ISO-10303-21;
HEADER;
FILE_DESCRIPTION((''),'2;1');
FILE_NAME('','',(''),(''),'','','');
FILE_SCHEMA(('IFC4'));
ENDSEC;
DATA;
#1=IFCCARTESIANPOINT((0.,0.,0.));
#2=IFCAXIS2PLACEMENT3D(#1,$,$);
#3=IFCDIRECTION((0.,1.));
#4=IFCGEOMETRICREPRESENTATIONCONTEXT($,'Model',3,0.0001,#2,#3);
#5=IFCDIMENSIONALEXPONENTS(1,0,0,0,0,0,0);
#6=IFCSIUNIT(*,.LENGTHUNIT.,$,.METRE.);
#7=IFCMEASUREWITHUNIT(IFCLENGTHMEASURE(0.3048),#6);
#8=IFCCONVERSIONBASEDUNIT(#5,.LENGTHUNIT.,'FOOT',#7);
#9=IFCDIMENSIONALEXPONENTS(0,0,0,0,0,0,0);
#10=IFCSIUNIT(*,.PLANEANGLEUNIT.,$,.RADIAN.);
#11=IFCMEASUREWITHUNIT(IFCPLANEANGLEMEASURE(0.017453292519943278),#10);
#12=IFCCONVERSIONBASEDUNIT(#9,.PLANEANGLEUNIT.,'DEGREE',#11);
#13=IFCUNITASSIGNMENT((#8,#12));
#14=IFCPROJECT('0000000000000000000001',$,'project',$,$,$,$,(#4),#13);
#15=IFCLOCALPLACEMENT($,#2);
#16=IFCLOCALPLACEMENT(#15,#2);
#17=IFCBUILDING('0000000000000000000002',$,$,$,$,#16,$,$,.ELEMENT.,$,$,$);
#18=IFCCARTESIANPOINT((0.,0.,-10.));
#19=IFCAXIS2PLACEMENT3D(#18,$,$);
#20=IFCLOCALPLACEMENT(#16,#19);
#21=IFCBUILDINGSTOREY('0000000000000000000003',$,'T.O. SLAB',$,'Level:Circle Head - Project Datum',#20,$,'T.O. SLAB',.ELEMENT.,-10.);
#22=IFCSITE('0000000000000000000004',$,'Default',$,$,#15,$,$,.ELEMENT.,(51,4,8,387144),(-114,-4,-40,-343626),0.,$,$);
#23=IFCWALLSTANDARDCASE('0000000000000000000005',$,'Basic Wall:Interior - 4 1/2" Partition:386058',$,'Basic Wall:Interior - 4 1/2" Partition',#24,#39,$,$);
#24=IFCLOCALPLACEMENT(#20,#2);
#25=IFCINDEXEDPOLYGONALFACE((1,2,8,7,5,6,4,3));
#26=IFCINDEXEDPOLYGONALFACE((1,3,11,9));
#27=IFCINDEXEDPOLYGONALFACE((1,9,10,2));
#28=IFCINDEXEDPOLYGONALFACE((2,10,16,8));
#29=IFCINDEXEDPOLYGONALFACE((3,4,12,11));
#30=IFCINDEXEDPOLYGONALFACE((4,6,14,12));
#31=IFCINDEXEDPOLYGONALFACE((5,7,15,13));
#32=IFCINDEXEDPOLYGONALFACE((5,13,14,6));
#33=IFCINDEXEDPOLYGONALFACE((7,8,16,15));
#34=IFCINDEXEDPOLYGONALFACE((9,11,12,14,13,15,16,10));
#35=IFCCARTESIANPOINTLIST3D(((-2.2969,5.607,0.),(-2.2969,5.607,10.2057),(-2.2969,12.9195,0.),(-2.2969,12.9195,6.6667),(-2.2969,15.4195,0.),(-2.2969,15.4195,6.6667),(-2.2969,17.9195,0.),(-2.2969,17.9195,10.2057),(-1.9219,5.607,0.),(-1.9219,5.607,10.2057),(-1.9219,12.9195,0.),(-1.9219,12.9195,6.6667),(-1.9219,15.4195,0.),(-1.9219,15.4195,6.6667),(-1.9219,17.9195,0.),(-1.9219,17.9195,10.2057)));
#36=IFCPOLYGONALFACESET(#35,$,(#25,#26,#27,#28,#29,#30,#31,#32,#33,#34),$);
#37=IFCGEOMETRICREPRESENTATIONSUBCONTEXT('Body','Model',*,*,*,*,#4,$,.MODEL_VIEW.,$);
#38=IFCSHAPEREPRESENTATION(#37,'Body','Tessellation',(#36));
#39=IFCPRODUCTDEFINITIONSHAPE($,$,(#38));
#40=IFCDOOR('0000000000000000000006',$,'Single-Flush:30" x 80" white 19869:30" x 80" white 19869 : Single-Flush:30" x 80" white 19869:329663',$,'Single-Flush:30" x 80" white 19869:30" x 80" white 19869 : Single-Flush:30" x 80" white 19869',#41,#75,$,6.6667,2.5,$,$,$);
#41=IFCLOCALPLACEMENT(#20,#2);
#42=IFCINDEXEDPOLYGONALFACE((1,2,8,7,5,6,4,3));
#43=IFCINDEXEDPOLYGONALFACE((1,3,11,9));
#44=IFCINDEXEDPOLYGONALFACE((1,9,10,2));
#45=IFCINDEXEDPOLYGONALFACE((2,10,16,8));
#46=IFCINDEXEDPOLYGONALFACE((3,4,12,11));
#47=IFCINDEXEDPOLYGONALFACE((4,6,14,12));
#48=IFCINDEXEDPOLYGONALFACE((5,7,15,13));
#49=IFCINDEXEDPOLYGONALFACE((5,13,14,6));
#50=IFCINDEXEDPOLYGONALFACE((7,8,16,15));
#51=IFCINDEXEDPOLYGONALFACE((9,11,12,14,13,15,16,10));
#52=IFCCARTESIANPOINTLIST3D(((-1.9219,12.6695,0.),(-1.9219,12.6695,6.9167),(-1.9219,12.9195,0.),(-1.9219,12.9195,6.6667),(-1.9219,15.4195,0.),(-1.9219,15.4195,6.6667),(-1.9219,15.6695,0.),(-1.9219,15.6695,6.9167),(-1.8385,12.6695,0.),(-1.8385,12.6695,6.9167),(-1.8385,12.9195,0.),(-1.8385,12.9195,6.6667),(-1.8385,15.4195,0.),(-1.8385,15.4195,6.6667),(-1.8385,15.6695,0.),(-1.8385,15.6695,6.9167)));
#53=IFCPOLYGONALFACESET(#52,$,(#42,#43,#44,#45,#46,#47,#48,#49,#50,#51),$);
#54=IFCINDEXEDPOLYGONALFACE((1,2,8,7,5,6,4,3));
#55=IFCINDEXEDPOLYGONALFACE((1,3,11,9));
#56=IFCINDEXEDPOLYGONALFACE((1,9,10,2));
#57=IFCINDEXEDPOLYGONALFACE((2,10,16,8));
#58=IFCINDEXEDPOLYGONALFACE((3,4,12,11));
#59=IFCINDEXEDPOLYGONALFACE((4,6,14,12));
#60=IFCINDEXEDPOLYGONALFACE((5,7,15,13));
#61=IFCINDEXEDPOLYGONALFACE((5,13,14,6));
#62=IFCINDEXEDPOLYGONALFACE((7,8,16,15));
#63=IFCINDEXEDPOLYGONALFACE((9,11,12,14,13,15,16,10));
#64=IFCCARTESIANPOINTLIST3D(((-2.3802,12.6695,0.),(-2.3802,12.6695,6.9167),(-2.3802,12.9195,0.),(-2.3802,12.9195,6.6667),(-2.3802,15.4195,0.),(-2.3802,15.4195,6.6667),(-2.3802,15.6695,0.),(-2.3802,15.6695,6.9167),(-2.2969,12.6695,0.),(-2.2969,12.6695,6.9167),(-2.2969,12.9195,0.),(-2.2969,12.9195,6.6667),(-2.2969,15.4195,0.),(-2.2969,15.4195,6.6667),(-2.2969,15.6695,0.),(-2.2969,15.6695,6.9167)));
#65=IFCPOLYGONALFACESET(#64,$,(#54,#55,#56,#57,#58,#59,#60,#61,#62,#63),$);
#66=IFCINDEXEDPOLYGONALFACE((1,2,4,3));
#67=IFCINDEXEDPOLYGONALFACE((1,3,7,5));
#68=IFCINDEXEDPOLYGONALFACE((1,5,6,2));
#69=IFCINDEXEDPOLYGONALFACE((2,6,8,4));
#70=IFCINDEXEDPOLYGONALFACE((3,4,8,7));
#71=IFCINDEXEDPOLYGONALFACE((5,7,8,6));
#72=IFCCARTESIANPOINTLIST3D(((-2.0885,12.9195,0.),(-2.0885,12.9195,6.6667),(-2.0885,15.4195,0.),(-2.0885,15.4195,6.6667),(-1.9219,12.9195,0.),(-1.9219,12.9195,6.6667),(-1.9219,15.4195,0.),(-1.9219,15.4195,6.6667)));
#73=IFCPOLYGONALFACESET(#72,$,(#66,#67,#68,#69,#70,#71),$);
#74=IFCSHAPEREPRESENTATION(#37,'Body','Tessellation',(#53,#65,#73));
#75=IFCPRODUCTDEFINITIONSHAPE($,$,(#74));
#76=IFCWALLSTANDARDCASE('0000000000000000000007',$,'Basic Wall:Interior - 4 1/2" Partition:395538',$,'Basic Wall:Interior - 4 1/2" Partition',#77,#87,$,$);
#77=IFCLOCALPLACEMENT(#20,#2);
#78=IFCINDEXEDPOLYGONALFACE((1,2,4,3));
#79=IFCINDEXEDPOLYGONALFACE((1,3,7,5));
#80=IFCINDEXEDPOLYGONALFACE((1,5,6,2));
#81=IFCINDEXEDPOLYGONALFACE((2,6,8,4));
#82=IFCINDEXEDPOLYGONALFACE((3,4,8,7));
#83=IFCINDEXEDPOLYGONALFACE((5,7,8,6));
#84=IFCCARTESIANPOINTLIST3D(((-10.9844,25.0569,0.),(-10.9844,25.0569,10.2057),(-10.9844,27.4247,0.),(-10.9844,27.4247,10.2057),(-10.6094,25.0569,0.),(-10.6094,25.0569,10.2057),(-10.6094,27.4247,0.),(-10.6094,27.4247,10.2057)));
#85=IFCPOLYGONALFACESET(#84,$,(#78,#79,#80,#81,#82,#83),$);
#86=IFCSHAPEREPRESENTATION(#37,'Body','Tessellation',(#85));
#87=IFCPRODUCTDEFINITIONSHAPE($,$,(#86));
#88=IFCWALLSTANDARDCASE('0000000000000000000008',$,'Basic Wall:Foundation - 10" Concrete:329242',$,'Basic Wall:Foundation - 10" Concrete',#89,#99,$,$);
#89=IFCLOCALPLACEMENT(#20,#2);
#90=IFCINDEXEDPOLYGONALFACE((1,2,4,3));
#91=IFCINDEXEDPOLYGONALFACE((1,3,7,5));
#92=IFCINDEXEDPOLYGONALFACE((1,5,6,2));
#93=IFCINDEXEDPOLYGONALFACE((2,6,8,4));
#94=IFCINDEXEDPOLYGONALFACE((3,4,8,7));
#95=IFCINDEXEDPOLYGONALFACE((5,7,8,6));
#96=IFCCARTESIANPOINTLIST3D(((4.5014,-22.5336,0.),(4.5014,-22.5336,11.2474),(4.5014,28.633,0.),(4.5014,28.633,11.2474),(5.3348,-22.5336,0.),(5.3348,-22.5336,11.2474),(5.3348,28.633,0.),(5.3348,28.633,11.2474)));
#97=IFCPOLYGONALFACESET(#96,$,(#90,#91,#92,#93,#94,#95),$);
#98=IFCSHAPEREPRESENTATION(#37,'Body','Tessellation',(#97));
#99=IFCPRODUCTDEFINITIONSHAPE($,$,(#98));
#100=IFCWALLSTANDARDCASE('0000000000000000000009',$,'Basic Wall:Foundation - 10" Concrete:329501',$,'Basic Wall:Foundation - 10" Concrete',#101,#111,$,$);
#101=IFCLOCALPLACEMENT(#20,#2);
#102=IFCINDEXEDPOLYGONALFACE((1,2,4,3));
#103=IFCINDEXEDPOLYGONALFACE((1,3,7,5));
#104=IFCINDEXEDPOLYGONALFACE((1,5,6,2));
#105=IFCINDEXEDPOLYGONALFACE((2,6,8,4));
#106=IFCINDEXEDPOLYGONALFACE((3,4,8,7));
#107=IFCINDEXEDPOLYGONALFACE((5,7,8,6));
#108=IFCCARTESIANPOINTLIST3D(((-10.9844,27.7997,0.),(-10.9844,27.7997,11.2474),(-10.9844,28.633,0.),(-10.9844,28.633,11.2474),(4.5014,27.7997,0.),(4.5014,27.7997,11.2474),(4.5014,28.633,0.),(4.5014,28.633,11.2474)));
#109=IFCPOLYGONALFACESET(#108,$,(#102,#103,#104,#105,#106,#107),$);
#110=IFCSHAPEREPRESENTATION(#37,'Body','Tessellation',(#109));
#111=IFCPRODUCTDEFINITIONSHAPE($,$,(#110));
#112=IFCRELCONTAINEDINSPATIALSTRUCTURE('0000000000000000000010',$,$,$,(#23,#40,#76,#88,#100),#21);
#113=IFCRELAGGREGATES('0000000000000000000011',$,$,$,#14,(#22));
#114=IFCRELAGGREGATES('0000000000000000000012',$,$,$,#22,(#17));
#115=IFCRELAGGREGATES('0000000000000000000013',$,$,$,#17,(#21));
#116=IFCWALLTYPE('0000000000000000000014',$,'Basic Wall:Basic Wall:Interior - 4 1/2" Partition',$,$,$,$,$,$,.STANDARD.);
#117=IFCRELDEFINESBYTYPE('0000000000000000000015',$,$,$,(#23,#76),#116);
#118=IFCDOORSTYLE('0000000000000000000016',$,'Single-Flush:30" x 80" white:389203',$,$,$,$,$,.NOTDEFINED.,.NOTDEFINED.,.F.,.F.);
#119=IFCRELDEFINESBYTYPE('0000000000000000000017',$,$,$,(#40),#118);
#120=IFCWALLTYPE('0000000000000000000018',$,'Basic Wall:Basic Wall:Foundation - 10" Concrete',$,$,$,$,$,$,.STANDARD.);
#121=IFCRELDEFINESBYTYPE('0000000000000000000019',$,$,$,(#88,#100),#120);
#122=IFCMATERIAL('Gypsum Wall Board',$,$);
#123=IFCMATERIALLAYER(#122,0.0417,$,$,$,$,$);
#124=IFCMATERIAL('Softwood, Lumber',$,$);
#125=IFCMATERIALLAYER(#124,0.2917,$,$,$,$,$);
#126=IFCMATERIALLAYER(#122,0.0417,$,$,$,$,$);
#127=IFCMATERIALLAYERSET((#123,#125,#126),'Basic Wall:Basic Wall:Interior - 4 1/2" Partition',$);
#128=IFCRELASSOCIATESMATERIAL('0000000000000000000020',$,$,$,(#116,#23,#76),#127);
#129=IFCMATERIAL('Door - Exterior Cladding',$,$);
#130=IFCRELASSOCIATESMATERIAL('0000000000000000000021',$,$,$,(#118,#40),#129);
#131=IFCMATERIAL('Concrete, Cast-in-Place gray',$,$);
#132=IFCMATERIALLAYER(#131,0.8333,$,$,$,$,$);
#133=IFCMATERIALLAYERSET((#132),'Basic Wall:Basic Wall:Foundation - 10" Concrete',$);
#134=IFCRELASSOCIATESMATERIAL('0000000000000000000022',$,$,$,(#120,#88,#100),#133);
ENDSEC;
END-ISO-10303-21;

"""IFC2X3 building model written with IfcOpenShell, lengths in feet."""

from ifc_helpers import new_model, entity, si_unit, converted_unit, direction, frame, frame_2d, origin, place, context, subcontext, project, spatial, polyline, rectangle, outline, extrude, source, transform, mapped, material, layer, layer_set, layer_usage, type_object, type_shapes, element, fill, save


model = new_model("IFC2X3")

# Units and contexts
model_context = context("Model", 3, precision=0.0001, world=origin(), true_north=direction((0.0, 1.0)))
body_context = subcontext(model_context, "Body", "Model", "MODEL_VIEW")
ifc_project = project(units=[converted_unit("LENGTHUNIT", "FOOT", entity("IfcLengthMeasure", 0.3048), si_unit("LENGTHUNIT", "METRE"), dimensions=[1, 0, 0, 0, 0, 0, 0]), converted_unit("PLANEANGLEUNIT", "DEGREE", entity("IfcPlaneAngleMeasure", 0.017453292519943278), si_unit("PLANEANGLEUNIT", "RADIAN"), dimensions=[0, 0, 0, 0, 0, 0, 0])], contexts=[model_context])

# Site, building, storey
site_placement = place(None, origin())
site = spatial("IfcSite", under=ifc_project, at=site_placement, Name="Default", CompositionType="ELEMENT", RefLatitude=(51, 4, 8, 387144), RefLongitude=(-114, -4, -40, -343626), RefElevation=0.0)
building_placement = place(site_placement, origin())
building = spatial("IfcBuilding", under=site, at=building_placement, CompositionType="ELEMENT")
storey_placement = place(building_placement, frame((0.0, 0.0, -10.0)))
storey = spatial("IfcBuildingStorey", under=building, at=storey_placement, Name="T.O. SLAB", ObjectType="Level:Circle Head - Project Datum", LongName="T.O. SLAB", CompositionType="ELEMENT", Elevation=-10.0)

# Shared definitions
ifc_material_1 = material(Name="Gypsum Wall Board")
ifc_layer_1 = layer(ifc_material_1, 0.0417)
ifc_material_2 = material(Name="Softwood, Lumber")
ifc_layer_2 = layer(ifc_material_2, 0.2917)
ifc_layer_3 = layer(ifc_material_1, 0.0417)
ifc_layer_set_1 = layer_set([ifc_layer_1, ifc_layer_2, ifc_layer_3], Name="Basic Wall:Basic Wall:Interior - 4 1/2\" Partition")
wall_type_1 = type_object("IfcWallType", Name="Basic Wall:Basic Wall:Interior - 4 1/2\" Partition", PredefinedType="STANDARD", material=ifc_layer_set_1)
ifc_material_3 = material(Name="Door - Exterior Cladding")

# Wall, opening, door
ifc_layer_usage_1 = layer_usage(ifc_layer_set_1, "AXIS2", "NEGATIVE", 0.1875)
wall_1_placement = place(storey_placement, frame((-2.1094, 17.9195, 0.0), z_axis=(0.0, 0.0, 1.0), x_axis=(0.0, -1.0, 0.0)))
wall_1 = element("IfcWallStandardCase", 1, at=wall_1_placement, inside=storey, type_object=wall_type_1, material=ifc_layer_usage_1, Name="Basic Wall:Interior - 4 1/2\" Partition:386058", ObjectType="Basic Wall:Interior - 4 1/2\" Partition", context=body_context, shape_type="SweptSolid", body=[
    extrude(rectangle(XDim=12.3125, YDim=0.375, at=frame_2d((6.1563, 0.0), x_axis=(1.0, 0.0))), origin(), (0.0, 0.0, 1.0), 10.2057),
])
opening_1_placement = place(wall_1_placement, frame((17.9195, 2.1094, 0.0), z_axis=(0.0, 0.0, 1.0), x_axis=(0.0, 1.0, 0.0)))
opening_1 = element("IfcOpeningElement", 2, at=opening_1_placement, cuts=wall_1, ObjectType="Opening", context=body_context, shape_type="SweptSolid", body=[
    extrude(rectangle(XDim=6.6667, YDim=2.5, at=frame_2d((0.0, 0.0), x_axis=(1.0, 0.0))), frame((-2.3006, 14.1695, 3.3333), z_axis=(1.0, 0.0, 0.0), x_axis=(0.0, 0.0, 1.0)), (0.0, 0.0, 1.0), 0.3825),
])
door_style_1 = type_object("IfcDoorStyle", Name="Single-Flush:30\" x 80\" white:389203", ConstructionType="NOTDEFINED", OperationType="NOTDEFINED", ParameterTakesPrecedence=False, Sizeable=False, material=ifc_material_3)
shared_shape_1 = source(origin(), body_context, "Body", "SweptSolid", [
    extrude(outline(polyline([(-1.5, -3.5208), (1.5, -3.5208), (1.5, 3.3958), (1.25, 3.3958), (1.25, -3.2708), (-1.25, -3.2708), (-1.25, 3.3958), (-1.5, 3.3958), (-1.5, -3.5208)])), frame((1.25, -0.0038, 3.3958), z_axis=(0.0, 1.0, 0.0), x_axis=(1.0, 0.0, 0.0)), (0.0, 0.0, 1.0), 0.0833),
    extrude(outline(polyline([(-3.3958, -1.5), (3.5208, -1.5), (3.5208, 1.5), (-3.3958, 1.5), (-3.3958, 1.25), (3.2708, 1.25), (3.2708, -1.25), (-3.3958, -1.25), (-3.3958, -1.5)])), frame((1.25, -0.4621, 3.3958), z_axis=(0.0, 1.0, 0.0), x_axis=(0.0, 0.0, 1.0)), (0.0, 0.0, 1.0), 0.0833),
    extrude(rectangle(XDim=0.1667, YDim=2.5, at=frame_2d((0.0, 0.0), x_axis=(1.0, 0.0))), frame((1.25, -0.0871, 0.0), z_axis=(0.0, 0.0, 1.0), x_axis=(0.0, 1.0, 0.0)), (0.0, 0.0, 1.0), 6.6667),
])
type_shapes(door_style_1, [shared_shape_1])
door_1_placement = place(opening_1_placement, frame((-1.9181, 15.4195, 0.0), z_axis=(0.0, 0.0, 1.0), x_axis=(0.0, -1.0, 0.0)))
door_1 = element("IfcDoor", 3, at=door_1_placement, inside=storey, type_object=door_style_1, material=ifc_material_3, Name="Single-Flush:30\" x 80\" white 19869:30\" x 80\" white 19869 : Single-Flush:30\" x 80\" white 19869:329663", ObjectType="Single-Flush:30\" x 80\" white 19869:30\" x 80\" white 19869 : Single-Flush:30\" x 80\" white 19869", OverallHeight=6.6667, OverallWidth=2.5, context=body_context, shape_type="MappedRepresentation", body=[
    mapped(shared_shape_1, transform((0.0, 0.0, 0.0), scale=1.0)),
])
fill(opening_1, door_1)

# Walls
ifc_layer_usage_2 = layer_usage(ifc_layer_set_1, "AXIS2", "NEGATIVE", 0.1875)
wall_2_placement = place(storey_placement, frame((-10.7969, 25.0569, 0.0), z_axis=(0.0, 0.0, 1.0), x_axis=(0.0, 1.0, 0.0)))
element("IfcWallStandardCase", 4, at=wall_2_placement, inside=storey, type_object=wall_type_1, material=ifc_layer_usage_2, Name="Basic Wall:Interior - 4 1/2\" Partition:395538", ObjectType="Basic Wall:Interior - 4 1/2\" Partition", context=body_context, shape_type="SweptSolid", body=[
    extrude(rectangle(XDim=2.3678, YDim=0.375, at=frame_2d((1.1839, 0.0), x_axis=(-1.0, 0.0))), origin(), (0.0, 0.0, 1.0), 10.2057),
])
ifc_material_4 = material(Name="Concrete, Cast-in-Place gray")
ifc_layer_4 = layer(ifc_material_4, 0.8333)
ifc_layer_set_2 = layer_set([ifc_layer_4], Name="Basic Wall:Basic Wall:Foundation - 10\" Concrete")
ifc_layer_usage_3 = layer_usage(ifc_layer_set_2, "AXIS2", "NEGATIVE", 0.4167)
wall_type_2 = type_object("IfcWallType", Name="Basic Wall:Basic Wall:Foundation - 10\" Concrete", PredefinedType="STANDARD", material=ifc_layer_set_2)
wall_3_placement = place(storey_placement, frame((4.9181, 28.633, 0.0), z_axis=(0.0, 0.0, 1.0), x_axis=(0.0, -1.0, 0.0)))
element("IfcWallStandardCase", 5, at=wall_3_placement, inside=storey, type_object=wall_type_2, material=ifc_layer_usage_3, Name="Basic Wall:Foundation - 10\" Concrete:329242", ObjectType="Basic Wall:Foundation - 10\" Concrete", context=body_context, shape_type="SweptSolid", body=[
    extrude(rectangle(XDim=51.1667, YDim=0.8333, at=frame_2d((25.5833, 0.0), x_axis=(-1.0, 0.0))), origin(), (0.0, 0.0, 1.0), 11.2474),
])
ifc_layer_usage_4 = layer_usage(ifc_layer_set_2, "AXIS2", "NEGATIVE", 0.4167)
wall_4_placement = place(storey_placement, frame((-10.9844, 28.2164, 0.0)))
element("IfcWallStandardCase", 6, at=wall_4_placement, inside=storey, type_object=wall_type_2, material=ifc_layer_usage_4, Name="Basic Wall:Foundation - 10\" Concrete:329501", ObjectType="Basic Wall:Foundation - 10\" Concrete", context=body_context, shape_type="SweptSolid", body=[
    extrude(rectangle(XDim=15.4858, YDim=0.8333, at=frame_2d((7.7429, 0.0), x_axis=(-1.0, 0.0))), origin(), (0.0, 0.0, 1.0), 11.2474),
])

save(model, "model.ifc")
